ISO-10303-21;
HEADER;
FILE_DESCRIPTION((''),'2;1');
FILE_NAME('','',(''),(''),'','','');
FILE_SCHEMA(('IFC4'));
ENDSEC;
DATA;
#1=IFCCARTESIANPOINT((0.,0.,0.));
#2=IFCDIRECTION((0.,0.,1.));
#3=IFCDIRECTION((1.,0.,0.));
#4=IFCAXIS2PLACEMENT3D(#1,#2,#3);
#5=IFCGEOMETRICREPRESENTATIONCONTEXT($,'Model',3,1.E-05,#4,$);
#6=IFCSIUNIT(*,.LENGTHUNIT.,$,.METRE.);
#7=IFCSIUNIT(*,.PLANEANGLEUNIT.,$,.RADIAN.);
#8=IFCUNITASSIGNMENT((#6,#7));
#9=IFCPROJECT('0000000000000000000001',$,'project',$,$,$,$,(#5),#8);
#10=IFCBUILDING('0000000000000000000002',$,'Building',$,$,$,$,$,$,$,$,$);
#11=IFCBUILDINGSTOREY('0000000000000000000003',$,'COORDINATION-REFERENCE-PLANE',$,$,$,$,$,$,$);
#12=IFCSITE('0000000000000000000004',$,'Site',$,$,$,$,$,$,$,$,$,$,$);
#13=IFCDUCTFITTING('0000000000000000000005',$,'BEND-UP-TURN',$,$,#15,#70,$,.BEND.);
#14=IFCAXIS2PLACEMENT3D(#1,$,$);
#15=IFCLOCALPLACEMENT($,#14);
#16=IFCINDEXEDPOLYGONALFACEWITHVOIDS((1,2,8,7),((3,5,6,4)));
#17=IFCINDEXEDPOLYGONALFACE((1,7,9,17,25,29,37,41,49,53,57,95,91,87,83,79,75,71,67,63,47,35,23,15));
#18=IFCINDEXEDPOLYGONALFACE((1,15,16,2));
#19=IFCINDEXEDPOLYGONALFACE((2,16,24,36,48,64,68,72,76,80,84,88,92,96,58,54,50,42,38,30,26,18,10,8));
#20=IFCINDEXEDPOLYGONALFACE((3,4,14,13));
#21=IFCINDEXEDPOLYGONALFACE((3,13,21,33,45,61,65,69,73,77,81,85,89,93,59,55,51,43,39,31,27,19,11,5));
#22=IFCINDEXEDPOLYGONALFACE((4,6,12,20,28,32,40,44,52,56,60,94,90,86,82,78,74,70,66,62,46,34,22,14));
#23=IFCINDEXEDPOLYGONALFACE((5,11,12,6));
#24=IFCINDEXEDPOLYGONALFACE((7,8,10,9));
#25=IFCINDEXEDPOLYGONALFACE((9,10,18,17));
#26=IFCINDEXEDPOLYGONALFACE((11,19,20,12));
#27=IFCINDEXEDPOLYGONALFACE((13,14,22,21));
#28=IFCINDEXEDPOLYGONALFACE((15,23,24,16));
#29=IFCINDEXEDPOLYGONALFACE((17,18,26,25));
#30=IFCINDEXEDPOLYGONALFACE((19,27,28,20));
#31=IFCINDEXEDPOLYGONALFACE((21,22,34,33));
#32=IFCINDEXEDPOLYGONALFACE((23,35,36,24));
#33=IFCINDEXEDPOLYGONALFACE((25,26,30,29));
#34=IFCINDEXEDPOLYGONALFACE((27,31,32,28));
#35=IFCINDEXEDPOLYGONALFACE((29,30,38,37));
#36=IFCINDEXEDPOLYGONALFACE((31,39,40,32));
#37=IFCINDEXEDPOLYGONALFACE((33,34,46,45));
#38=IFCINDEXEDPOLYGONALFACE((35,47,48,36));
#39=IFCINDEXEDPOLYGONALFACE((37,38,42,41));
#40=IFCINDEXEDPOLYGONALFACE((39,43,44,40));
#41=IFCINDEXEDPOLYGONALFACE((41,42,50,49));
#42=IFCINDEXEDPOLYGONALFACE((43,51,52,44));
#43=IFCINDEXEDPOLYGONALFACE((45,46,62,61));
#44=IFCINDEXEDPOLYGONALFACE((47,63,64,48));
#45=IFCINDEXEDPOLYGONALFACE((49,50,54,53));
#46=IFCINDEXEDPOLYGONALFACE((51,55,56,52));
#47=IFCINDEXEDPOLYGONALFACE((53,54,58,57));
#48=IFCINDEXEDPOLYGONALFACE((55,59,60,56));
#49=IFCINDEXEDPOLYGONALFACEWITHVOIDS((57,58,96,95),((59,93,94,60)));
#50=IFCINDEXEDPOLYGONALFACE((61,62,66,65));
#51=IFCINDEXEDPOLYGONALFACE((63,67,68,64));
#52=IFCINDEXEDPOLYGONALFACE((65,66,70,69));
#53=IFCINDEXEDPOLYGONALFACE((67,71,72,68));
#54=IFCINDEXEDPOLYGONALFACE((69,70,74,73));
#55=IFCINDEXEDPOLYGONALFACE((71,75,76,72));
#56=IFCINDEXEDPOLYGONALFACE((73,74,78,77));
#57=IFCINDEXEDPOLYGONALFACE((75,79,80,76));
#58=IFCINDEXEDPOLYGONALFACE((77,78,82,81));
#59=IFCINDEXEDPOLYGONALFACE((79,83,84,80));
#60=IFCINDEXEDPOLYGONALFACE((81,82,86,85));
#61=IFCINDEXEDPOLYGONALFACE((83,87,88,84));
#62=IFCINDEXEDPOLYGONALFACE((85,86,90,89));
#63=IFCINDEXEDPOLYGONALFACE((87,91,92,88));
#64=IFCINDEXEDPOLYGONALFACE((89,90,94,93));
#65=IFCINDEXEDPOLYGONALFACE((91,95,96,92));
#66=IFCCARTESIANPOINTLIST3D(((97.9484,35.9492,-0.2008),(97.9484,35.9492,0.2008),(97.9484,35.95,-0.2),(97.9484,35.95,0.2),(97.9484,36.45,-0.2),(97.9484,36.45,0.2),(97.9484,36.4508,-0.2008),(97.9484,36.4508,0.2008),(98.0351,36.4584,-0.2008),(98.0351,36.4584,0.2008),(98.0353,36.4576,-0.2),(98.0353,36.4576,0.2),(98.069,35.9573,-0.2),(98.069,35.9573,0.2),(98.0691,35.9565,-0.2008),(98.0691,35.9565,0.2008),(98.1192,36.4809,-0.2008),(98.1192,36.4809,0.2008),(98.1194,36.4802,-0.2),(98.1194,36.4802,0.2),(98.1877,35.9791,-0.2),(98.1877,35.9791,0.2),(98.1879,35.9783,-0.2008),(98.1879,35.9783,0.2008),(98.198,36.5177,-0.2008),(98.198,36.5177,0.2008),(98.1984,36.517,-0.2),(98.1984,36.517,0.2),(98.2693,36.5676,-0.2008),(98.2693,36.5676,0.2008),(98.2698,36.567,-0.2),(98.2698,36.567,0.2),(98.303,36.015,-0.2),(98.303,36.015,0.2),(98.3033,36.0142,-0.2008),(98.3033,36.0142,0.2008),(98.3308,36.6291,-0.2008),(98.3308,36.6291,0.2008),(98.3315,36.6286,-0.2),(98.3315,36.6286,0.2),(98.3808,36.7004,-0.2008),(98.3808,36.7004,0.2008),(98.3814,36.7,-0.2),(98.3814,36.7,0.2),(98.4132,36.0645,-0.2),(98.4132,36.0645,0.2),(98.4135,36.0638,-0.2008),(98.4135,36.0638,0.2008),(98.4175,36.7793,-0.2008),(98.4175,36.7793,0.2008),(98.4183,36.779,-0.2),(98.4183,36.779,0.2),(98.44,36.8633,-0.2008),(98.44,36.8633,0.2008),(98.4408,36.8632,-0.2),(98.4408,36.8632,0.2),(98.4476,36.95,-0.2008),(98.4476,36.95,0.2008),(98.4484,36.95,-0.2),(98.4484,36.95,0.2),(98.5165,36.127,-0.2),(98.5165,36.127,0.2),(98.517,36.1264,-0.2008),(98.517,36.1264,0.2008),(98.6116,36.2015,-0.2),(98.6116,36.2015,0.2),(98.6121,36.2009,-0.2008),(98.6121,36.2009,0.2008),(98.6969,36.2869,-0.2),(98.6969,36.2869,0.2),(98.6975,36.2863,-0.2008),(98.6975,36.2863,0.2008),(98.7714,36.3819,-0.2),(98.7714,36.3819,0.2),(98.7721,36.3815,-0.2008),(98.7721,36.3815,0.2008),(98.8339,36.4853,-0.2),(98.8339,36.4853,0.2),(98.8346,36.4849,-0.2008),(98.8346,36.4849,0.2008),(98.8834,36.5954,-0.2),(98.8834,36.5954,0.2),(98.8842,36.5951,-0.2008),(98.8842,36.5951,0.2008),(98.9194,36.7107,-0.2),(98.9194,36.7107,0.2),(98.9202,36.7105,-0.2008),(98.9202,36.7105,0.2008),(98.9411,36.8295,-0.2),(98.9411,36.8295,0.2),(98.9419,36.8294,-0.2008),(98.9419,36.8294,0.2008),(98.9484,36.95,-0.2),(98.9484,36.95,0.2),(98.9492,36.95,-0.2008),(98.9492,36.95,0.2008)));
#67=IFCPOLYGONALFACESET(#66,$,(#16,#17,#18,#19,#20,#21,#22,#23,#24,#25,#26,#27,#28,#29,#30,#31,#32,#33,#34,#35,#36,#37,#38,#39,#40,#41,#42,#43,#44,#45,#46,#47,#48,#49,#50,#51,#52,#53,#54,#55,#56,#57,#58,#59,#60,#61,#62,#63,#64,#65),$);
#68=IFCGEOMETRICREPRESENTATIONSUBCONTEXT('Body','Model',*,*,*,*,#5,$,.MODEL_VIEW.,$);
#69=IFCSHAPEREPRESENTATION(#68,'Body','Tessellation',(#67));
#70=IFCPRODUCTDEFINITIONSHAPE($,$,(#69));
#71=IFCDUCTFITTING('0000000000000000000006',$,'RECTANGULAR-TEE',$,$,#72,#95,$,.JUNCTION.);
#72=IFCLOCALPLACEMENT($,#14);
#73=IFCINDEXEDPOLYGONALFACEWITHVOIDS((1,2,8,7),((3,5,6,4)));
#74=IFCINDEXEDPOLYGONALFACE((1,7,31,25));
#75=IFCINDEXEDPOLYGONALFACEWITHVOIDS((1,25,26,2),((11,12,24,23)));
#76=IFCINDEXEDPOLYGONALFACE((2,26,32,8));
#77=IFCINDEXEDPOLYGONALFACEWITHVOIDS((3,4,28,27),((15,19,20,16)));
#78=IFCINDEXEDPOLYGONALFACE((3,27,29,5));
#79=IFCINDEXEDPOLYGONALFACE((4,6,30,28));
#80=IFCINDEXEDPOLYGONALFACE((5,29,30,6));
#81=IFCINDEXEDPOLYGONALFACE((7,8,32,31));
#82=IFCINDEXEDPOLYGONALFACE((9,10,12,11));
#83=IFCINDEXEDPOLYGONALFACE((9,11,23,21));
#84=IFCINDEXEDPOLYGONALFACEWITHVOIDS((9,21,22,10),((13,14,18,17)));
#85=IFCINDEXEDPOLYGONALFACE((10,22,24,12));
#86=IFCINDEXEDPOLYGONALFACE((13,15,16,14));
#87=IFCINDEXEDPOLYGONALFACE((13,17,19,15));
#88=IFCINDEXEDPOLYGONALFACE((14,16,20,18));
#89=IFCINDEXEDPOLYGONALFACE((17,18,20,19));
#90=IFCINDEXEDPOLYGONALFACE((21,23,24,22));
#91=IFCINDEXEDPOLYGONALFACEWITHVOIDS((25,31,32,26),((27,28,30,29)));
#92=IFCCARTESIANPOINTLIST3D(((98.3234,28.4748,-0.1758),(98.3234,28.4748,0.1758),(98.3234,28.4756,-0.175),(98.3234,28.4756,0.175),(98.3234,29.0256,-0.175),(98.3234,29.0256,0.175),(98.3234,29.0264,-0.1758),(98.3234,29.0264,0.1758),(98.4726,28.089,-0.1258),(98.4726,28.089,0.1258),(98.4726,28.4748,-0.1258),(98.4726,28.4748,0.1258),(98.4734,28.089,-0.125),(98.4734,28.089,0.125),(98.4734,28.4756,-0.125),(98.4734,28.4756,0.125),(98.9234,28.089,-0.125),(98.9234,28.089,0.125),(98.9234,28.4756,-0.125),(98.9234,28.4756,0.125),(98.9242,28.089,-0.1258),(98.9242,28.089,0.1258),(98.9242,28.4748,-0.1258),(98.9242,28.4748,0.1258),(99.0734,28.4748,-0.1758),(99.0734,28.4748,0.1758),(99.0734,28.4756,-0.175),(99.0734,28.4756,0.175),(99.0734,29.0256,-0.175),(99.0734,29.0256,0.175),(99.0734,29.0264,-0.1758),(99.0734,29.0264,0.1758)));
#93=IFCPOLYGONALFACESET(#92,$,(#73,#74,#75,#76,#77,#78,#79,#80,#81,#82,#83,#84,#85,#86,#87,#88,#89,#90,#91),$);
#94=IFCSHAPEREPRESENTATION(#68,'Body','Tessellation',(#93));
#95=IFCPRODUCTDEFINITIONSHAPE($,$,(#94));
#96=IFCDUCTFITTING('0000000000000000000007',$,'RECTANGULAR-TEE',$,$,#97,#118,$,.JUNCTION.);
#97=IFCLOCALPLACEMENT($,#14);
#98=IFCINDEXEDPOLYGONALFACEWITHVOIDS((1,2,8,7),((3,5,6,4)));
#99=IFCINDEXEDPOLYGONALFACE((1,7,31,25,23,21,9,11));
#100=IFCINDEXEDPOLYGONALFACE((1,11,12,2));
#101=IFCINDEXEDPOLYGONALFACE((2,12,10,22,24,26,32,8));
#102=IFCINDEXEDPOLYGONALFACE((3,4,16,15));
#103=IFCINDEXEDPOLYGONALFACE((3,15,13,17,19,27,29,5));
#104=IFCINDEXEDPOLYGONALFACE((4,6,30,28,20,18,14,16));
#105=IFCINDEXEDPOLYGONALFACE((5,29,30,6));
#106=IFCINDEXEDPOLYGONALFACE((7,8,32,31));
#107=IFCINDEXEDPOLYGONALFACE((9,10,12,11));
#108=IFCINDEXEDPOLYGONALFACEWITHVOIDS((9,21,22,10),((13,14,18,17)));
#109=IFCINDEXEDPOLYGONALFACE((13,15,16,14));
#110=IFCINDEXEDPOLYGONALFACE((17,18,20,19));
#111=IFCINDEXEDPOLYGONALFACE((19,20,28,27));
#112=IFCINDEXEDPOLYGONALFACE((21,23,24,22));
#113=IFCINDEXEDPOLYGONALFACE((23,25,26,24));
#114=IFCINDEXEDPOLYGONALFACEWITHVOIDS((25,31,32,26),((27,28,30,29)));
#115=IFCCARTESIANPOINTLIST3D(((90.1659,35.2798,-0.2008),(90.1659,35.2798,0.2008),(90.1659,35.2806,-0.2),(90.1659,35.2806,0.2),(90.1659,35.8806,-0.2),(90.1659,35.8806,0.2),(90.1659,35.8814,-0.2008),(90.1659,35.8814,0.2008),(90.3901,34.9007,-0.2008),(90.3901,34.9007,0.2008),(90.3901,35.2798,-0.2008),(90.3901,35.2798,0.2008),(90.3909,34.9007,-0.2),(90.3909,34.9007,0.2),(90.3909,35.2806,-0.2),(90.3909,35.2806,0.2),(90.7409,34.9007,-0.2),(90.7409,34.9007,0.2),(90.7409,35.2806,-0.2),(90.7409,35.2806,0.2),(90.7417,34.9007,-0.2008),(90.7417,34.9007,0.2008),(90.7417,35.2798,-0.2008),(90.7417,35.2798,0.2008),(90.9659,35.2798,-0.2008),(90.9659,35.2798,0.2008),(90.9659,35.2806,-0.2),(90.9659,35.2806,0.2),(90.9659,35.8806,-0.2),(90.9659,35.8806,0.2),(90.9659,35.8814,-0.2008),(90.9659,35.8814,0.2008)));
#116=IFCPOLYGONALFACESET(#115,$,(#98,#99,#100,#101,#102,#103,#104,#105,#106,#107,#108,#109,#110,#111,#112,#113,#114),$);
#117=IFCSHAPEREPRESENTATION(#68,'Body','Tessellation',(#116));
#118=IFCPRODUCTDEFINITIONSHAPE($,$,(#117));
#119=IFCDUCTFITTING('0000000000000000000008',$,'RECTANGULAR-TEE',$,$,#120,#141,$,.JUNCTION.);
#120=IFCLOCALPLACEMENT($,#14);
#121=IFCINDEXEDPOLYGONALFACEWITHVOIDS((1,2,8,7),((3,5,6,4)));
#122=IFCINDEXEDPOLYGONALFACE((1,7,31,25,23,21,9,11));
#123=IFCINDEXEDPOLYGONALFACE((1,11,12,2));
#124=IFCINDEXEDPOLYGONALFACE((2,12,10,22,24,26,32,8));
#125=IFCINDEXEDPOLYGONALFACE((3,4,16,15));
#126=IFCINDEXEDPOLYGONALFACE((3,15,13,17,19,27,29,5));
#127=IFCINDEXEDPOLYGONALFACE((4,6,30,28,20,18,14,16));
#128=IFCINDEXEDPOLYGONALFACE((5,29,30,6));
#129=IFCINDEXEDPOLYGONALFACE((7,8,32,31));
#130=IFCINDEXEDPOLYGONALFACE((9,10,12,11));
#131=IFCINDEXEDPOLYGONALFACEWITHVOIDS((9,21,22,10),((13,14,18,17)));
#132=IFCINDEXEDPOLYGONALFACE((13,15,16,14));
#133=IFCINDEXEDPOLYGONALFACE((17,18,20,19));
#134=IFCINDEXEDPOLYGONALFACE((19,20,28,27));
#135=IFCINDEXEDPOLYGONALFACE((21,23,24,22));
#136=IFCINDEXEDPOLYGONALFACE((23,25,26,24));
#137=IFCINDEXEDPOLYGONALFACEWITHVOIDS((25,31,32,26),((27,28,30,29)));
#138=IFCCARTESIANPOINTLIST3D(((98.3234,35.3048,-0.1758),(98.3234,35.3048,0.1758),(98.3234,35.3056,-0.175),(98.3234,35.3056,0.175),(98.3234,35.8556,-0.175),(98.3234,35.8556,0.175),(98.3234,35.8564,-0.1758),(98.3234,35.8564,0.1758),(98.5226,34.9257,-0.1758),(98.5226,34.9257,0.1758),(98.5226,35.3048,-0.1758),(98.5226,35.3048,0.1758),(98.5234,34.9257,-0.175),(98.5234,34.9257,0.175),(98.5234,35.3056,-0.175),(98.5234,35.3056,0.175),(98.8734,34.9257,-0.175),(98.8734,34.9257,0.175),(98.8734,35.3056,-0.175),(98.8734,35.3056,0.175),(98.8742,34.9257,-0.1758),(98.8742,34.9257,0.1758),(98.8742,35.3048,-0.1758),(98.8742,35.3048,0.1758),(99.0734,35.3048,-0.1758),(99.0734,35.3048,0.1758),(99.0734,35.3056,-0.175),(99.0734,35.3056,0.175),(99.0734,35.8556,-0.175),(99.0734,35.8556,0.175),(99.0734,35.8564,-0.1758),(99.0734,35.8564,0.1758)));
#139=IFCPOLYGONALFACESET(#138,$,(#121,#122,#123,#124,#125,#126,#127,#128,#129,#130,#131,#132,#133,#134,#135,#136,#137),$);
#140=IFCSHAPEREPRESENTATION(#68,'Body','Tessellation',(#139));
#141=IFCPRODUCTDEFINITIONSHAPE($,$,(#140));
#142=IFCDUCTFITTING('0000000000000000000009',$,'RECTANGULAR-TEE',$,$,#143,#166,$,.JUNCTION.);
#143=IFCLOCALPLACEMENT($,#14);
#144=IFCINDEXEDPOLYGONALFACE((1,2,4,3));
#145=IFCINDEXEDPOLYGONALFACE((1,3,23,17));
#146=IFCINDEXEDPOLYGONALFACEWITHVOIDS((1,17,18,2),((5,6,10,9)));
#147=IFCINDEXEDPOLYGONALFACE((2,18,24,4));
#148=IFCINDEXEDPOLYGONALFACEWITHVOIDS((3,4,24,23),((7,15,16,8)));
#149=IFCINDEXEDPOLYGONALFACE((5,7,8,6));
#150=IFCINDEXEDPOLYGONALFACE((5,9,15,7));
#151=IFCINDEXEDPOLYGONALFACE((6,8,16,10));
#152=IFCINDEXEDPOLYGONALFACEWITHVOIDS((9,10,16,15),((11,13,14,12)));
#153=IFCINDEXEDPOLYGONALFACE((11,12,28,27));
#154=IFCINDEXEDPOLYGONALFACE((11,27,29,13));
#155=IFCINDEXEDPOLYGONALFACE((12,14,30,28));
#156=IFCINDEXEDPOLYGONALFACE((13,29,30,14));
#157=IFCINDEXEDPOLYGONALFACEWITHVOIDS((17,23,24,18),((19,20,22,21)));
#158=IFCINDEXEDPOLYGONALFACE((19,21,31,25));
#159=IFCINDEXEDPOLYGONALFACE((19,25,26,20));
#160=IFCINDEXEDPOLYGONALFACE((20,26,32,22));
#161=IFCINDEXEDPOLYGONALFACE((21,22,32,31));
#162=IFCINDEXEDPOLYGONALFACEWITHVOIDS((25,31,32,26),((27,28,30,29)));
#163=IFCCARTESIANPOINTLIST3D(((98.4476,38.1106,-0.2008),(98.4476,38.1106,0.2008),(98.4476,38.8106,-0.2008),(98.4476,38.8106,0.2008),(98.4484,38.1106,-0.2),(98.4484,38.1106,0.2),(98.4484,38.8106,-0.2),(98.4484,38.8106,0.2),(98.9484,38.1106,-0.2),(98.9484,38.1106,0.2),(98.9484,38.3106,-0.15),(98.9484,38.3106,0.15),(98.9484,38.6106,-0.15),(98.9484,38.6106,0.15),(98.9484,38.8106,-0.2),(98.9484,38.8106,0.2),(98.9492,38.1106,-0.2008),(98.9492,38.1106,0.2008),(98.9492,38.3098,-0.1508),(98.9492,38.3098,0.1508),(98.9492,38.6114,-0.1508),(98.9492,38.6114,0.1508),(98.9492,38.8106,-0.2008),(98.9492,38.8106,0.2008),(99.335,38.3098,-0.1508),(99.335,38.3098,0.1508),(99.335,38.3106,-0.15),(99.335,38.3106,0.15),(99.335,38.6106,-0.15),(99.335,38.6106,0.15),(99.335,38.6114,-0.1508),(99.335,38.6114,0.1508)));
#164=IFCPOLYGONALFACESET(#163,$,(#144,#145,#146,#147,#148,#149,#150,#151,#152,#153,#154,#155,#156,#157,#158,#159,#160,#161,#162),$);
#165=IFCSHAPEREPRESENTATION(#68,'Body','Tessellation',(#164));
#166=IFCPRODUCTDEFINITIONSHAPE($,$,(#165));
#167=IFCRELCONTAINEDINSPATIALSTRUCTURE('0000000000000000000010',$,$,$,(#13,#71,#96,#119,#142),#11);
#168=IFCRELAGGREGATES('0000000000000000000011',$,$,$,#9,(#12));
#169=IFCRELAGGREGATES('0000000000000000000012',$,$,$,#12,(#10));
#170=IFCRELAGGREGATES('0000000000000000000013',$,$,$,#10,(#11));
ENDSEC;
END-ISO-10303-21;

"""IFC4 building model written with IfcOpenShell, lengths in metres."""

from ifc_helpers import new_model, entity, si_unit, frame, origin_with_axes, place, context, subcontext, project, spatial, rectangle, extrude, boolean, element, save


model = new_model("IFC4")

# Units and contexts
model_context = context("Model", 3, precision=1e-05, world=origin_with_axes())
body_context_1 = subcontext(model_context, "Body", "Model", "MODEL_VIEW")
ifc_project = project(units=[si_unit("LENGTHUNIT", "METRE"), si_unit("PLANEANGLEUNIT", "RADIAN")], contexts=[model_context])

# Site, building, storey
site = spatial("IfcSite", under=ifc_project, Name="Site")
building = spatial("IfcBuilding", under=site, Name="Building")
storey = spatial("IfcBuildingStorey", under=building, Name="COORDINATION-REFERENCE-PLANE")

# Duct fittings
duct_fitting_1_placement = place(None, frame((97.9484, 36.95, 0.0), z_axis=(0.0, 0.0, 1.0), x_axis=(0.0, -1.0, 0.0)))
cartesian_point_1 = entity("IfcCartesianPoint", [0.0, 0.0, 0.0])
element("IfcDuctFitting", 1, at=duct_fitting_1_placement, inside=storey, Name="BEND-UP-TURN", PredefinedType="BEND", context=body_context_1, shape_type="SweptSolid", body=[
    entity("IfcRevolvedAreaSolid", entity("IfcRectangleHollowProfileDef", "AREA", None, entity("IfcAxis2Placement2D", entity("IfcCartesianPoint", [0.75, 0.0])), 0.5016, 0.4016, 0.0008), entity("IfcAxis2Placement3D", cartesian_point_1, entity("IfcDirection", [0.0, -1.0, 0.0]), entity("IfcDirection", [1.0, 0.0, 0.0])), entity("IfcAxis1Placement", cartesian_point_1, entity("IfcDirection", [0.0, 1.0, 0.0])), 1.570796),
])
duct_fitting_2_placement = place(None, frame((98.6984, 28.7506, 0.0), z_axis=(1.0, 0.0, 0.0), x_axis=(0.0, -1.0, 0.0)))
solid_1 = boolean("UNION", extrude(rectangle(XDim=0.55, YDim=0.35), frame((0.0, 0.0, -0.375), z_axis=(0.0, 0.0, 1.0), x_axis=(1.0, 0.0, 0.0)), (0.0, 0.0, 1.0), 0.75), extrude(rectangle(XDim=0.45, YDim=0.25), frame((0.0, 0.0, 0.0), z_axis=(1.0, 0.0, 0.0), x_axis=(0.0, 0.0, -1.0)), (0.0, 0.0, 1.0), 0.6616))
element("IfcDuctFitting", 2, at=duct_fitting_2_placement, inside=storey, Name="RECTANGULAR-TEE", PredefinedType="JUNCTION", context=body_context_1, shape_type="CSG", body=[
    boolean("DIFFERENCE", boolean("UNION", extrude(rectangle(XDim=0.5516, YDim=0.3516), frame((0.0, 0.0, -0.375), z_axis=(0.0, 0.0, 1.0), x_axis=(1.0, 0.0, 0.0)), (0.0, 0.0, 1.0), 0.75), extrude(rectangle(XDim=0.4516, YDim=0.2516), frame((0.0, 0.0, 0.0), z_axis=(1.0, 0.0, 0.0), x_axis=(0.0, 0.0, -1.0)), (0.0, 0.0, 1.0), 0.6616)), solid_1),
])
duct_fitting_3_placement = place(None, frame((90.5659, 35.5806, 0.0), z_axis=(1.0, 0.0, 0.0), x_axis=(0.0, -1.0, 0.0)))
solid_2 = boolean("UNION", extrude(rectangle(XDim=0.6, YDim=0.4), frame((0.0, 0.0, -0.4), z_axis=(0.0, 0.0, 1.0), x_axis=(1.0, 0.0, 0.0)), (0.0, 0.0, 1.0), 0.8), extrude(rectangle(XDim=0.35, YDim=0.4), frame((0.0, 0.0, 0.0), z_axis=(1.0, 0.0, 0.0), x_axis=(0.0, 0.0, -1.0)), (0.0, 0.0, 1.0), 0.6799))
element("IfcDuctFitting", 3, at=duct_fitting_3_placement, inside=storey, Name="RECTANGULAR-TEE", PredefinedType="JUNCTION", context=body_context_1, shape_type="CSG", body=[
    boolean("DIFFERENCE", boolean("UNION", extrude(rectangle(XDim=0.6016, YDim=0.4016), frame((0.0, 0.0, -0.4), z_axis=(0.0, 0.0, 1.0), x_axis=(1.0, 0.0, 0.0)), (0.0, 0.0, 1.0), 0.8), extrude(rectangle(XDim=0.3516, YDim=0.4016), frame((0.0, 0.0, 0.0), z_axis=(1.0, 0.0, 0.0), x_axis=(0.0, 0.0, -1.0)), (0.0, 0.0, 1.0), 0.6799)), solid_2),
])
duct_fitting_4_placement = place(None, frame((98.6984, 35.5806, 0.0), z_axis=(1.0, 0.0, 0.0), x_axis=(0.0, -1.0, 0.0)))
solid_3 = boolean("UNION", extrude(rectangle(XDim=0.55, YDim=0.35), frame((0.0, 0.0, -0.375), z_axis=(0.0, 0.0, 1.0), x_axis=(1.0, 0.0, 0.0)), (0.0, 0.0, 1.0), 0.75), extrude(rectangle(XDim=0.35, YDim=0.35), frame((0.0, 0.0, 0.0), z_axis=(1.0, 0.0, 0.0), x_axis=(0.0, 0.0, -1.0)), (0.0, 0.0, 1.0), 0.6549))
element("IfcDuctFitting", 4, at=duct_fitting_4_placement, inside=storey, Name="RECTANGULAR-TEE", PredefinedType="JUNCTION", context=body_context_1, shape_type="CSG", body=[
    boolean("DIFFERENCE", boolean("UNION", extrude(rectangle(XDim=0.5516, YDim=0.3516), frame((0.0, 0.0, -0.375), z_axis=(0.0, 0.0, 1.0), x_axis=(1.0, 0.0, 0.0)), (0.0, 0.0, 1.0), 0.75), extrude(rectangle(XDim=0.3516, YDim=0.3516), frame((0.0, 0.0, 0.0), z_axis=(1.0, 0.0, 0.0), x_axis=(0.0, 0.0, -1.0)), (0.0, 0.0, 1.0), 0.6549)), solid_3),
])
duct_fitting_5_placement = place(None, frame((98.6984, 38.4606, 0.0), z_axis=(0.0, 1.0, 0.0), x_axis=(1.0, 0.0, 0.0)))
solid_4 = boolean("UNION", extrude(rectangle(XDim=0.5, YDim=0.4), frame((0.0, 0.0, -0.35), z_axis=(0.0, 0.0, 1.0), x_axis=(1.0, 0.0, 0.0)), (0.0, 0.0, 1.0), 0.7), extrude(rectangle(XDim=0.3, YDim=0.3), frame((0.0, 0.0, 0.0), z_axis=(1.0, 0.0, 0.0), x_axis=(0.0, 0.0, -1.0)), (0.0, 0.0, 1.0), 0.6366))
element("IfcDuctFitting", 5, at=duct_fitting_5_placement, inside=storey, Name="RECTANGULAR-TEE", PredefinedType="JUNCTION", context=body_context_1, shape_type="CSG", body=[
    boolean("DIFFERENCE", boolean("UNION", extrude(rectangle(XDim=0.5016, YDim=0.4016), frame((0.0, 0.0, -0.35), z_axis=(0.0, 0.0, 1.0), x_axis=(1.0, 0.0, 0.0)), (0.0, 0.0, 1.0), 0.7), extrude(rectangle(XDim=0.3016, YDim=0.3016), frame((0.0, 0.0, 0.0), z_axis=(1.0, 0.0, 0.0), x_axis=(0.0, 0.0, -1.0)), (0.0, 0.0, 1.0), 0.6366)), solid_4),
])

save(model, "model.ifc")
